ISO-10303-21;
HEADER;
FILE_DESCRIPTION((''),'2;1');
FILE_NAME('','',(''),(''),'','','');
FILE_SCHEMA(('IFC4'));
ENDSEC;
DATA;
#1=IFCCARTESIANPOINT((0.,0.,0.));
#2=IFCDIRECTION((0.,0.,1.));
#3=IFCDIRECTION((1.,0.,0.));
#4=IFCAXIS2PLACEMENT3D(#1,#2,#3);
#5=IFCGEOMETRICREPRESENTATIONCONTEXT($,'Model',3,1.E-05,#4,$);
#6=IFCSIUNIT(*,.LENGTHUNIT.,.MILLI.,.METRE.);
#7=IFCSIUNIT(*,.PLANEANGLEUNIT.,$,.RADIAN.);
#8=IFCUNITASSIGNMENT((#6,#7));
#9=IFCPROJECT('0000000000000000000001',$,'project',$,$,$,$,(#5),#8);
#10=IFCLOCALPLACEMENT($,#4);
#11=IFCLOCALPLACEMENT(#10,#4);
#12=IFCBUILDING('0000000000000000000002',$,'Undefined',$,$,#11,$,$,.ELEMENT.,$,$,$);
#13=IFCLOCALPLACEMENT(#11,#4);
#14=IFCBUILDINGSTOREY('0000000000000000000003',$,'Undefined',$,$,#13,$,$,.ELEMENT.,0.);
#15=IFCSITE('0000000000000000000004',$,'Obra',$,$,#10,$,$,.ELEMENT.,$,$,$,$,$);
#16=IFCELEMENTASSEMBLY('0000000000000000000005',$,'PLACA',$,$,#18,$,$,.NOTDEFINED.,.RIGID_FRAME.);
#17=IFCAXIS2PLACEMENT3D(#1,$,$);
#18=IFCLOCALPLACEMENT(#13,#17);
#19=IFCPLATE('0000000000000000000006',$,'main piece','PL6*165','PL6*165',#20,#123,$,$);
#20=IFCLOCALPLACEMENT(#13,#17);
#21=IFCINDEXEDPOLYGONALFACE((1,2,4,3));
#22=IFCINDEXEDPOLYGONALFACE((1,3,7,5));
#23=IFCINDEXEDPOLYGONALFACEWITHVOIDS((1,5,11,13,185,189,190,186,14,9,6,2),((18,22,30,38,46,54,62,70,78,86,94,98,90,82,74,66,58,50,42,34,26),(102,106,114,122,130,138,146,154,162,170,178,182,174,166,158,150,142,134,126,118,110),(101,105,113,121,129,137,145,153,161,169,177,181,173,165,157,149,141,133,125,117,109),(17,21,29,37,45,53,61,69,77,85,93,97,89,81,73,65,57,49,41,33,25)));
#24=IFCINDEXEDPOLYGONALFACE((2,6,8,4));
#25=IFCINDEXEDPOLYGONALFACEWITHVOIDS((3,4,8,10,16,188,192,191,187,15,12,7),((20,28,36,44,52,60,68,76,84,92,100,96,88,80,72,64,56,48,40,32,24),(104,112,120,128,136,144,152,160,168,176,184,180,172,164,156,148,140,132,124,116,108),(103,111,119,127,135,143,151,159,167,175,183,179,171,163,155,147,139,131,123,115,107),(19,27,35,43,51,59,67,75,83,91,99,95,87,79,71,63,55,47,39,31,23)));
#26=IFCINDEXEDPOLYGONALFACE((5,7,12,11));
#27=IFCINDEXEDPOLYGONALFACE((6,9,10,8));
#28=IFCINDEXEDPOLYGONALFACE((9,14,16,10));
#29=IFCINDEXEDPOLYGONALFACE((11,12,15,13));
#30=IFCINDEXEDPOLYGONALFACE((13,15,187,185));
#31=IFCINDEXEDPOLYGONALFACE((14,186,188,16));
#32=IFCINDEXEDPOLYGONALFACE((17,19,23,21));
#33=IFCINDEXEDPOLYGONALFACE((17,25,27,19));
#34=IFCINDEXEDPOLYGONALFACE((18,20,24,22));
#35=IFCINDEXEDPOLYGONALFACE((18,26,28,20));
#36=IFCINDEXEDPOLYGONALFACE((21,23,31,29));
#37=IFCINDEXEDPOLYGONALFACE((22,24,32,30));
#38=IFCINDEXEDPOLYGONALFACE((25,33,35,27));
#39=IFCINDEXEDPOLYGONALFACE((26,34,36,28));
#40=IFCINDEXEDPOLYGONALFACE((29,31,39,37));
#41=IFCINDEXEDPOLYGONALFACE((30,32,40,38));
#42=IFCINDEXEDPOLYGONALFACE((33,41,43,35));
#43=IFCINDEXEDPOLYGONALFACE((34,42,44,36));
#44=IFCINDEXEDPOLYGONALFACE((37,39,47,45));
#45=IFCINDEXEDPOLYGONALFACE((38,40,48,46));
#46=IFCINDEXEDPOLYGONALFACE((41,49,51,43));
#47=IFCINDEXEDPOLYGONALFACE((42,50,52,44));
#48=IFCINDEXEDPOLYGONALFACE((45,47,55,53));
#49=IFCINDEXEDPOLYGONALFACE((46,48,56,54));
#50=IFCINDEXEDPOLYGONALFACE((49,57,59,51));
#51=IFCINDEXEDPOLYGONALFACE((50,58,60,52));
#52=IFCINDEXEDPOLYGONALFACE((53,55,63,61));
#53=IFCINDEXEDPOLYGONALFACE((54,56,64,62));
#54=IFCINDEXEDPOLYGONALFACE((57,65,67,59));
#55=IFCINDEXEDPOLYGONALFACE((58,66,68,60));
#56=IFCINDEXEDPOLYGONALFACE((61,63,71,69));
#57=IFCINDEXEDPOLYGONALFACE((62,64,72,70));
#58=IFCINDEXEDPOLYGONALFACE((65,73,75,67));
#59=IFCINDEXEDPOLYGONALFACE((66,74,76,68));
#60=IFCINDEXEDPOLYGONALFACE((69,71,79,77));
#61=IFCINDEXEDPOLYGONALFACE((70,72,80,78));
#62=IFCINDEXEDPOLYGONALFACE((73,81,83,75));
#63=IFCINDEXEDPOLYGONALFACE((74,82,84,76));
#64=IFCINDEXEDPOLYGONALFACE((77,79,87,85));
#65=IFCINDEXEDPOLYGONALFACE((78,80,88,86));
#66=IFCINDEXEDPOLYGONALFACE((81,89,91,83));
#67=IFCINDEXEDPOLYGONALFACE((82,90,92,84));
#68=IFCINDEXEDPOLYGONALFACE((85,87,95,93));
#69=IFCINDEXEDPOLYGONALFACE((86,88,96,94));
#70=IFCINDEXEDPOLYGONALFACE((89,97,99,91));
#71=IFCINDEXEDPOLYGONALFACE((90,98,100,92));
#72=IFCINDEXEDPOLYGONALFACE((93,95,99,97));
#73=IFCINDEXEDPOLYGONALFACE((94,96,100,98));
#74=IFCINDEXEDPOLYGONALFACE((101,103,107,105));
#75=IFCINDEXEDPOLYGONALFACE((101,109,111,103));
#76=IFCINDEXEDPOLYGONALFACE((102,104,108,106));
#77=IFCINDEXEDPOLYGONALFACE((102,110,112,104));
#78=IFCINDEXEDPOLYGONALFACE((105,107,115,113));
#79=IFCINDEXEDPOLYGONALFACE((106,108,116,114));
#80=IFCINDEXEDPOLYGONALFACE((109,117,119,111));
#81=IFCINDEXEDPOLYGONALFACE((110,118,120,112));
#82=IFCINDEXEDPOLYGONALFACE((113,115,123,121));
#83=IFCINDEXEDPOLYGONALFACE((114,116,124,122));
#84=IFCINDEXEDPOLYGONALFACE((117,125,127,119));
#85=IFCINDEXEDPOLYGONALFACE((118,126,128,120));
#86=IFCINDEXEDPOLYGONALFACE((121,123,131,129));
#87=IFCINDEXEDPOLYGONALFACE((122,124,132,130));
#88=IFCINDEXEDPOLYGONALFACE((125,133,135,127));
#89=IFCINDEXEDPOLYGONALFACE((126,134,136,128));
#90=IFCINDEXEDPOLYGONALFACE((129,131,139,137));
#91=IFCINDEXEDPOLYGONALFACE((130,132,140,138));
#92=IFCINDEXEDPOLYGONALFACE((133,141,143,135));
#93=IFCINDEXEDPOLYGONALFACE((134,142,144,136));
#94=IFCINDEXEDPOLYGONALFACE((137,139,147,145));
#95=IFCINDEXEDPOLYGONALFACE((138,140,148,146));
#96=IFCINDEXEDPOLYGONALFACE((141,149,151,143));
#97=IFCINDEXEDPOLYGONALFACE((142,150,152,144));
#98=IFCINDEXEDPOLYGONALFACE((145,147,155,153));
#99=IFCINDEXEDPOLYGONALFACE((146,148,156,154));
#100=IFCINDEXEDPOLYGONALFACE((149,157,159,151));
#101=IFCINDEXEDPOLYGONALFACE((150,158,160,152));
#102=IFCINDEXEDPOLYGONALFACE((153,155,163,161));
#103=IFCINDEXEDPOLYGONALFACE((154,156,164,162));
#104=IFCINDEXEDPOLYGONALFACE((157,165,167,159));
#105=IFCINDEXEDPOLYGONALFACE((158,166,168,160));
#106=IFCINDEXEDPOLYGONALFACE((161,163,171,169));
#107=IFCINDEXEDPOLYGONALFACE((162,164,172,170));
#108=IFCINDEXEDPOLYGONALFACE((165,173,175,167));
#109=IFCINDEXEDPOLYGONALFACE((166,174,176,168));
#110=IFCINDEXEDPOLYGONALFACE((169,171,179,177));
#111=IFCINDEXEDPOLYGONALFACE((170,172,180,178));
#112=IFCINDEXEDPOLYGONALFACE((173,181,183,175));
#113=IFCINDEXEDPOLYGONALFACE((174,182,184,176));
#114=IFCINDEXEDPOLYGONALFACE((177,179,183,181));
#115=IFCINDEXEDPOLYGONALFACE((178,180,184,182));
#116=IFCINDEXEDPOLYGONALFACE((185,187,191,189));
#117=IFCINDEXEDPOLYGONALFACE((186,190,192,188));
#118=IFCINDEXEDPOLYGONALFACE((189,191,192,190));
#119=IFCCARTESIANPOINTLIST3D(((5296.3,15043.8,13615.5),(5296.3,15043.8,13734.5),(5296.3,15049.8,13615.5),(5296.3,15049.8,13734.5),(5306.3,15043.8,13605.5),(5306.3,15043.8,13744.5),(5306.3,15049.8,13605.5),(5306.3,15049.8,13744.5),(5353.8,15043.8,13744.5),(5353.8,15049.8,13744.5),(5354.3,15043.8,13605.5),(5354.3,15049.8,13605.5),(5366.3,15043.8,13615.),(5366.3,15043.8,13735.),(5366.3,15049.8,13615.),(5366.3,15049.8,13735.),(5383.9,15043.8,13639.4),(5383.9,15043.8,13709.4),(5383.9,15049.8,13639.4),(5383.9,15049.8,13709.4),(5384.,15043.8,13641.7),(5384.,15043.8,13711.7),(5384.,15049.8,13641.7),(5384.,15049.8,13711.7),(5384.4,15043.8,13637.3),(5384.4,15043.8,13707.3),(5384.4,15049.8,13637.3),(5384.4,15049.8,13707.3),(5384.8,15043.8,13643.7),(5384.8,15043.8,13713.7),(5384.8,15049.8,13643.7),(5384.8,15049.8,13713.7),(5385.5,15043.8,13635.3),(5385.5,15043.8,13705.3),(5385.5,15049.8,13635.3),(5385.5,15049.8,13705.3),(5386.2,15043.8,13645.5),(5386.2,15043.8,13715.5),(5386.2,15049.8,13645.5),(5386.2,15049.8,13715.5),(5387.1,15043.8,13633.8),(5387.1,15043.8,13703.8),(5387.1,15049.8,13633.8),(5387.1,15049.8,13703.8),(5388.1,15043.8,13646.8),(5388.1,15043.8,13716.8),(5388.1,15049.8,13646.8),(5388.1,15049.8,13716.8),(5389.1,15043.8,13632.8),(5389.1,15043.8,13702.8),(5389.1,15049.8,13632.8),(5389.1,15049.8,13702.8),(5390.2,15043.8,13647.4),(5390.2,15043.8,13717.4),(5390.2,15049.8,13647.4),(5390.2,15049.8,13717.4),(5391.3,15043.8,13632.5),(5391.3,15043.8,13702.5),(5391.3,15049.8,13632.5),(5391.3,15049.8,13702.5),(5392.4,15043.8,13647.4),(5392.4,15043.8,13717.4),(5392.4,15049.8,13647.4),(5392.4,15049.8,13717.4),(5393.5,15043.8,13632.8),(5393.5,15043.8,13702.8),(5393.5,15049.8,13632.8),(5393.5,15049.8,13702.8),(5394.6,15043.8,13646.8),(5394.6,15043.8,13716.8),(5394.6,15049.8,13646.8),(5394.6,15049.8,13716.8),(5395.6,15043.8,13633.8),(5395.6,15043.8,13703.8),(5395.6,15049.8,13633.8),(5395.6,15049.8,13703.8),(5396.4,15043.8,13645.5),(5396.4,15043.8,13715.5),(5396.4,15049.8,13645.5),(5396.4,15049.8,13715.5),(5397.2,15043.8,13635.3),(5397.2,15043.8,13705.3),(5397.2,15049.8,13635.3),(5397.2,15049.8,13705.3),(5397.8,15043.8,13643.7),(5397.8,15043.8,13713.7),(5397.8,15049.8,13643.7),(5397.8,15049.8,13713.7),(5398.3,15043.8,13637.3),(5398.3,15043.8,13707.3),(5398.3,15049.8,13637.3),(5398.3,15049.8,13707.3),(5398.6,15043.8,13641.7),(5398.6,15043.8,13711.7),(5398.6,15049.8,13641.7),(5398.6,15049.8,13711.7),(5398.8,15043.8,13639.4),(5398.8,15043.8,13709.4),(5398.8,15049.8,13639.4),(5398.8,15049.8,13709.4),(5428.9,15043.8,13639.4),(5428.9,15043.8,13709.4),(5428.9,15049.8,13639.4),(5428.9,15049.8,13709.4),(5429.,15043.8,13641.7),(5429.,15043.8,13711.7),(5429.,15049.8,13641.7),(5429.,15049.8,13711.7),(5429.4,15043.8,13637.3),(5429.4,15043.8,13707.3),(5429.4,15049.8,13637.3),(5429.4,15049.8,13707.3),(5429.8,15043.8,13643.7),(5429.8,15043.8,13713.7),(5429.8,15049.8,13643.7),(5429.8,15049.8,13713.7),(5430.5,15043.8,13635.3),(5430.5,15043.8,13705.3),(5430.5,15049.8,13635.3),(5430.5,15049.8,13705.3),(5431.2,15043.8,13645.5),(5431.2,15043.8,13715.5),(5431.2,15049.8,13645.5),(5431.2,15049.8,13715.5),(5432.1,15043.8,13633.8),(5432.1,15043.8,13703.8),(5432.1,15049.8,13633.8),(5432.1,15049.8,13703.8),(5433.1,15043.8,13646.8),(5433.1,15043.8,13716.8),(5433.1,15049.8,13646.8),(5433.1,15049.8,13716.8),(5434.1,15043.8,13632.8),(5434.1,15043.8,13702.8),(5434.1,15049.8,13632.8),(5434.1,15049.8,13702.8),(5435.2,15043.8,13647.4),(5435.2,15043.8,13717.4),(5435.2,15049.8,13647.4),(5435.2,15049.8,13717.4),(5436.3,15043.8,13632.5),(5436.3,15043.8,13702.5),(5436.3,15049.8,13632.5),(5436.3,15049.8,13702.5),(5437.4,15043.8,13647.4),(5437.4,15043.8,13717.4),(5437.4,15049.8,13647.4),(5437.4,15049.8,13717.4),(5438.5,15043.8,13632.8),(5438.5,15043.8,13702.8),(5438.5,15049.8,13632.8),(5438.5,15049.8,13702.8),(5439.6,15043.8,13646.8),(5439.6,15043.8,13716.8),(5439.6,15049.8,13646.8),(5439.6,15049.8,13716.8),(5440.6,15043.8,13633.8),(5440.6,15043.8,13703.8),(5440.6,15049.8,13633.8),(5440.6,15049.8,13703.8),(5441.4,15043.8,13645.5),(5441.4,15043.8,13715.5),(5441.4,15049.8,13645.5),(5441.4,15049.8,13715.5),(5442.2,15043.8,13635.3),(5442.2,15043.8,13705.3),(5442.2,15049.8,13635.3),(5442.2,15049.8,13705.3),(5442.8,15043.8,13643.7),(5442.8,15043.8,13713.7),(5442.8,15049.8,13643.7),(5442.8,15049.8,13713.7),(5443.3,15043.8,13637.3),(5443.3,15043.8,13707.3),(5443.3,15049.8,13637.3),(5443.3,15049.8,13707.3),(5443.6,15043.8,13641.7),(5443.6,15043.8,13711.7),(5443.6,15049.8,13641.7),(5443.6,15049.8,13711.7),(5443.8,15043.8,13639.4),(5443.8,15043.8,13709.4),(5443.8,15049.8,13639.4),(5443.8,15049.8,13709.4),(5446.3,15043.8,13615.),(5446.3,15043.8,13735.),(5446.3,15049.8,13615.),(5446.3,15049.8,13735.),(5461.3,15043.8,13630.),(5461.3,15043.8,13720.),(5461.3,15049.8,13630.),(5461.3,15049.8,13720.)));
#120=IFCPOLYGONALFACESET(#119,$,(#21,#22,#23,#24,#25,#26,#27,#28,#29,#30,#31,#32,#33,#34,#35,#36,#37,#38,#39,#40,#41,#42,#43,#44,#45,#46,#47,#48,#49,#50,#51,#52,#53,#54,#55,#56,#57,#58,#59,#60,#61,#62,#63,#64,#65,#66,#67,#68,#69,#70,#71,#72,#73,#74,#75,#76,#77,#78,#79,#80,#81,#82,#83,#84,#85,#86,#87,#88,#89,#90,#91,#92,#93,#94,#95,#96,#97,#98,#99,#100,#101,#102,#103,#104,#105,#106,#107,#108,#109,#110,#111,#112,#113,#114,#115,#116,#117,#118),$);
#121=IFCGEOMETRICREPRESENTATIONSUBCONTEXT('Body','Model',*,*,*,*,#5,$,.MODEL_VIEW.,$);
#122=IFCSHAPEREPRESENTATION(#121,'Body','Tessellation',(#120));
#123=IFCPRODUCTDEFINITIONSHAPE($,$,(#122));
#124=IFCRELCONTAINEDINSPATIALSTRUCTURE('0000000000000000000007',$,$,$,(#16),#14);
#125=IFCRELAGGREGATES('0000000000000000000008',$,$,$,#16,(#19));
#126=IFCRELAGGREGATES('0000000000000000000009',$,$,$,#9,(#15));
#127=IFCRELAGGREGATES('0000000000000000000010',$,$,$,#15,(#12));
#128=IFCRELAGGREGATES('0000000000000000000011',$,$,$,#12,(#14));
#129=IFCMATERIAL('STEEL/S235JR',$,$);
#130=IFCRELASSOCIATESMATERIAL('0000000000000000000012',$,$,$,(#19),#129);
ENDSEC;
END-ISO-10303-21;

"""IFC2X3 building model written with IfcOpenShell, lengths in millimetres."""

from ifc_helpers import new_model, si_unit, frame, origin_with_axes, origin_2d_with_axis, place, context, subcontext, project, spatial, polyline, circle, outline, extrude, source, transform, mapped, material, element, aggregate, save


model = new_model("IFC2X3")

# Units and contexts
model_context = context("Model", 3, precision=1e-05, world=origin_with_axes())
body_context = subcontext(model_context, "Body", "Model", "MODEL_VIEW")
ifc_project = project(units=[si_unit("LENGTHUNIT", "METRE", prefix="MILLI"), si_unit("PLANEANGLEUNIT", "RADIAN")], contexts=[model_context])

# Site, building, storey
site_placement = place(None, origin_with_axes())
site = spatial("IfcSite", under=ifc_project, at=site_placement, Name="Obra", CompositionType="ELEMENT")
building_placement = place(site_placement, origin_with_axes())
building = spatial("IfcBuilding", under=site, at=building_placement, Name="Undefined", CompositionType="ELEMENT")
storey_placement = place(building_placement, origin_with_axes())
storey = spatial("IfcBuildingStorey", under=building, at=storey_placement, Name="Undefined", CompositionType="ELEMENT", Elevation=0.0)

# Shared definitions
ifc_material_1 = material(Name="STEEL/S235JR")

# Element assembly, plate, opening
assembly_1_placement = place(storey_placement, origin_with_axes())
assembly_1 = element("IfcElementAssembly", 1, at=assembly_1_placement, inside=storey, Name="PLACA", AssemblyPlace="NOTDEFINED", PredefinedType="RIGID_FRAME")
plate_1_placement = place(assembly_1_placement, frame((5296.3, 15046.8, 13615.5), z_axis=(0.0, -1.0, 0.0), x_axis=(0.707107, 0.0, -0.707107)))
plate_1 = element("IfcPlate", 2, at=plate_1_placement, material=ifc_material_1, Name="main piece", Description="PL6*165", ObjectType="PL6*165", context=body_context, shape_type="SweptSolid", body=[
    extrude(outline(polyline([(0.0, 0.0), (14.1, 0.0), (48.1, 33.9), (49.9, 49.1), (106.4, 105.7), (106.4, 126.9), (42.8, 190.6), (21.6, 190.6), (-35.0, 134.0), (-50.6, 131.9), (-84.1, 98.3), (-84.1, 84.1), (0.0, 0.0)])), frame((0.0, 0.0, -3.0), z_axis=(0.0, 0.0, 1.0), x_axis=(1.0, 0.0, 0.0)), (0.0, 0.0, 1.0), 6.0),
])
shared_shape_1 = source(origin_with_axes(), body_context, "Body", "SweptSolid", [
    extrude(circle(Radius=7.5, at=origin_2d_with_axis()), frame((0.0, 2.4, 0.0), z_axis=(0.0, 1.0, 0.0), x_axis=(1.0, 0.0, 0.0)), (0.0, 0.0, 1.0), 6.2),
])
opening_1_placement = place(assembly_1_placement, frame((5413.8, 15041.3, 13710.0), z_axis=(1.0, 0.0, 0.0), x_axis=(0.0, 0.0, -1.0)))
element("IfcOpeningElement", 3, at=opening_1_placement, cuts=plate_1, ObjectType="Opening", context=body_context, shape_type="MappedRepresentation", body=[
    mapped(shared_shape_1, transform((0.0, 0.0, -22.5))),
    mapped(shared_shape_1, transform((70.0, 0.0, -22.5))),
    mapped(shared_shape_1, transform((0.0, 0.0, 22.5))),
    mapped(shared_shape_1, transform((70.0, 0.0, 22.5))),
])
aggregate(assembly_1, [plate_1])

save(model, "model.ifc")
